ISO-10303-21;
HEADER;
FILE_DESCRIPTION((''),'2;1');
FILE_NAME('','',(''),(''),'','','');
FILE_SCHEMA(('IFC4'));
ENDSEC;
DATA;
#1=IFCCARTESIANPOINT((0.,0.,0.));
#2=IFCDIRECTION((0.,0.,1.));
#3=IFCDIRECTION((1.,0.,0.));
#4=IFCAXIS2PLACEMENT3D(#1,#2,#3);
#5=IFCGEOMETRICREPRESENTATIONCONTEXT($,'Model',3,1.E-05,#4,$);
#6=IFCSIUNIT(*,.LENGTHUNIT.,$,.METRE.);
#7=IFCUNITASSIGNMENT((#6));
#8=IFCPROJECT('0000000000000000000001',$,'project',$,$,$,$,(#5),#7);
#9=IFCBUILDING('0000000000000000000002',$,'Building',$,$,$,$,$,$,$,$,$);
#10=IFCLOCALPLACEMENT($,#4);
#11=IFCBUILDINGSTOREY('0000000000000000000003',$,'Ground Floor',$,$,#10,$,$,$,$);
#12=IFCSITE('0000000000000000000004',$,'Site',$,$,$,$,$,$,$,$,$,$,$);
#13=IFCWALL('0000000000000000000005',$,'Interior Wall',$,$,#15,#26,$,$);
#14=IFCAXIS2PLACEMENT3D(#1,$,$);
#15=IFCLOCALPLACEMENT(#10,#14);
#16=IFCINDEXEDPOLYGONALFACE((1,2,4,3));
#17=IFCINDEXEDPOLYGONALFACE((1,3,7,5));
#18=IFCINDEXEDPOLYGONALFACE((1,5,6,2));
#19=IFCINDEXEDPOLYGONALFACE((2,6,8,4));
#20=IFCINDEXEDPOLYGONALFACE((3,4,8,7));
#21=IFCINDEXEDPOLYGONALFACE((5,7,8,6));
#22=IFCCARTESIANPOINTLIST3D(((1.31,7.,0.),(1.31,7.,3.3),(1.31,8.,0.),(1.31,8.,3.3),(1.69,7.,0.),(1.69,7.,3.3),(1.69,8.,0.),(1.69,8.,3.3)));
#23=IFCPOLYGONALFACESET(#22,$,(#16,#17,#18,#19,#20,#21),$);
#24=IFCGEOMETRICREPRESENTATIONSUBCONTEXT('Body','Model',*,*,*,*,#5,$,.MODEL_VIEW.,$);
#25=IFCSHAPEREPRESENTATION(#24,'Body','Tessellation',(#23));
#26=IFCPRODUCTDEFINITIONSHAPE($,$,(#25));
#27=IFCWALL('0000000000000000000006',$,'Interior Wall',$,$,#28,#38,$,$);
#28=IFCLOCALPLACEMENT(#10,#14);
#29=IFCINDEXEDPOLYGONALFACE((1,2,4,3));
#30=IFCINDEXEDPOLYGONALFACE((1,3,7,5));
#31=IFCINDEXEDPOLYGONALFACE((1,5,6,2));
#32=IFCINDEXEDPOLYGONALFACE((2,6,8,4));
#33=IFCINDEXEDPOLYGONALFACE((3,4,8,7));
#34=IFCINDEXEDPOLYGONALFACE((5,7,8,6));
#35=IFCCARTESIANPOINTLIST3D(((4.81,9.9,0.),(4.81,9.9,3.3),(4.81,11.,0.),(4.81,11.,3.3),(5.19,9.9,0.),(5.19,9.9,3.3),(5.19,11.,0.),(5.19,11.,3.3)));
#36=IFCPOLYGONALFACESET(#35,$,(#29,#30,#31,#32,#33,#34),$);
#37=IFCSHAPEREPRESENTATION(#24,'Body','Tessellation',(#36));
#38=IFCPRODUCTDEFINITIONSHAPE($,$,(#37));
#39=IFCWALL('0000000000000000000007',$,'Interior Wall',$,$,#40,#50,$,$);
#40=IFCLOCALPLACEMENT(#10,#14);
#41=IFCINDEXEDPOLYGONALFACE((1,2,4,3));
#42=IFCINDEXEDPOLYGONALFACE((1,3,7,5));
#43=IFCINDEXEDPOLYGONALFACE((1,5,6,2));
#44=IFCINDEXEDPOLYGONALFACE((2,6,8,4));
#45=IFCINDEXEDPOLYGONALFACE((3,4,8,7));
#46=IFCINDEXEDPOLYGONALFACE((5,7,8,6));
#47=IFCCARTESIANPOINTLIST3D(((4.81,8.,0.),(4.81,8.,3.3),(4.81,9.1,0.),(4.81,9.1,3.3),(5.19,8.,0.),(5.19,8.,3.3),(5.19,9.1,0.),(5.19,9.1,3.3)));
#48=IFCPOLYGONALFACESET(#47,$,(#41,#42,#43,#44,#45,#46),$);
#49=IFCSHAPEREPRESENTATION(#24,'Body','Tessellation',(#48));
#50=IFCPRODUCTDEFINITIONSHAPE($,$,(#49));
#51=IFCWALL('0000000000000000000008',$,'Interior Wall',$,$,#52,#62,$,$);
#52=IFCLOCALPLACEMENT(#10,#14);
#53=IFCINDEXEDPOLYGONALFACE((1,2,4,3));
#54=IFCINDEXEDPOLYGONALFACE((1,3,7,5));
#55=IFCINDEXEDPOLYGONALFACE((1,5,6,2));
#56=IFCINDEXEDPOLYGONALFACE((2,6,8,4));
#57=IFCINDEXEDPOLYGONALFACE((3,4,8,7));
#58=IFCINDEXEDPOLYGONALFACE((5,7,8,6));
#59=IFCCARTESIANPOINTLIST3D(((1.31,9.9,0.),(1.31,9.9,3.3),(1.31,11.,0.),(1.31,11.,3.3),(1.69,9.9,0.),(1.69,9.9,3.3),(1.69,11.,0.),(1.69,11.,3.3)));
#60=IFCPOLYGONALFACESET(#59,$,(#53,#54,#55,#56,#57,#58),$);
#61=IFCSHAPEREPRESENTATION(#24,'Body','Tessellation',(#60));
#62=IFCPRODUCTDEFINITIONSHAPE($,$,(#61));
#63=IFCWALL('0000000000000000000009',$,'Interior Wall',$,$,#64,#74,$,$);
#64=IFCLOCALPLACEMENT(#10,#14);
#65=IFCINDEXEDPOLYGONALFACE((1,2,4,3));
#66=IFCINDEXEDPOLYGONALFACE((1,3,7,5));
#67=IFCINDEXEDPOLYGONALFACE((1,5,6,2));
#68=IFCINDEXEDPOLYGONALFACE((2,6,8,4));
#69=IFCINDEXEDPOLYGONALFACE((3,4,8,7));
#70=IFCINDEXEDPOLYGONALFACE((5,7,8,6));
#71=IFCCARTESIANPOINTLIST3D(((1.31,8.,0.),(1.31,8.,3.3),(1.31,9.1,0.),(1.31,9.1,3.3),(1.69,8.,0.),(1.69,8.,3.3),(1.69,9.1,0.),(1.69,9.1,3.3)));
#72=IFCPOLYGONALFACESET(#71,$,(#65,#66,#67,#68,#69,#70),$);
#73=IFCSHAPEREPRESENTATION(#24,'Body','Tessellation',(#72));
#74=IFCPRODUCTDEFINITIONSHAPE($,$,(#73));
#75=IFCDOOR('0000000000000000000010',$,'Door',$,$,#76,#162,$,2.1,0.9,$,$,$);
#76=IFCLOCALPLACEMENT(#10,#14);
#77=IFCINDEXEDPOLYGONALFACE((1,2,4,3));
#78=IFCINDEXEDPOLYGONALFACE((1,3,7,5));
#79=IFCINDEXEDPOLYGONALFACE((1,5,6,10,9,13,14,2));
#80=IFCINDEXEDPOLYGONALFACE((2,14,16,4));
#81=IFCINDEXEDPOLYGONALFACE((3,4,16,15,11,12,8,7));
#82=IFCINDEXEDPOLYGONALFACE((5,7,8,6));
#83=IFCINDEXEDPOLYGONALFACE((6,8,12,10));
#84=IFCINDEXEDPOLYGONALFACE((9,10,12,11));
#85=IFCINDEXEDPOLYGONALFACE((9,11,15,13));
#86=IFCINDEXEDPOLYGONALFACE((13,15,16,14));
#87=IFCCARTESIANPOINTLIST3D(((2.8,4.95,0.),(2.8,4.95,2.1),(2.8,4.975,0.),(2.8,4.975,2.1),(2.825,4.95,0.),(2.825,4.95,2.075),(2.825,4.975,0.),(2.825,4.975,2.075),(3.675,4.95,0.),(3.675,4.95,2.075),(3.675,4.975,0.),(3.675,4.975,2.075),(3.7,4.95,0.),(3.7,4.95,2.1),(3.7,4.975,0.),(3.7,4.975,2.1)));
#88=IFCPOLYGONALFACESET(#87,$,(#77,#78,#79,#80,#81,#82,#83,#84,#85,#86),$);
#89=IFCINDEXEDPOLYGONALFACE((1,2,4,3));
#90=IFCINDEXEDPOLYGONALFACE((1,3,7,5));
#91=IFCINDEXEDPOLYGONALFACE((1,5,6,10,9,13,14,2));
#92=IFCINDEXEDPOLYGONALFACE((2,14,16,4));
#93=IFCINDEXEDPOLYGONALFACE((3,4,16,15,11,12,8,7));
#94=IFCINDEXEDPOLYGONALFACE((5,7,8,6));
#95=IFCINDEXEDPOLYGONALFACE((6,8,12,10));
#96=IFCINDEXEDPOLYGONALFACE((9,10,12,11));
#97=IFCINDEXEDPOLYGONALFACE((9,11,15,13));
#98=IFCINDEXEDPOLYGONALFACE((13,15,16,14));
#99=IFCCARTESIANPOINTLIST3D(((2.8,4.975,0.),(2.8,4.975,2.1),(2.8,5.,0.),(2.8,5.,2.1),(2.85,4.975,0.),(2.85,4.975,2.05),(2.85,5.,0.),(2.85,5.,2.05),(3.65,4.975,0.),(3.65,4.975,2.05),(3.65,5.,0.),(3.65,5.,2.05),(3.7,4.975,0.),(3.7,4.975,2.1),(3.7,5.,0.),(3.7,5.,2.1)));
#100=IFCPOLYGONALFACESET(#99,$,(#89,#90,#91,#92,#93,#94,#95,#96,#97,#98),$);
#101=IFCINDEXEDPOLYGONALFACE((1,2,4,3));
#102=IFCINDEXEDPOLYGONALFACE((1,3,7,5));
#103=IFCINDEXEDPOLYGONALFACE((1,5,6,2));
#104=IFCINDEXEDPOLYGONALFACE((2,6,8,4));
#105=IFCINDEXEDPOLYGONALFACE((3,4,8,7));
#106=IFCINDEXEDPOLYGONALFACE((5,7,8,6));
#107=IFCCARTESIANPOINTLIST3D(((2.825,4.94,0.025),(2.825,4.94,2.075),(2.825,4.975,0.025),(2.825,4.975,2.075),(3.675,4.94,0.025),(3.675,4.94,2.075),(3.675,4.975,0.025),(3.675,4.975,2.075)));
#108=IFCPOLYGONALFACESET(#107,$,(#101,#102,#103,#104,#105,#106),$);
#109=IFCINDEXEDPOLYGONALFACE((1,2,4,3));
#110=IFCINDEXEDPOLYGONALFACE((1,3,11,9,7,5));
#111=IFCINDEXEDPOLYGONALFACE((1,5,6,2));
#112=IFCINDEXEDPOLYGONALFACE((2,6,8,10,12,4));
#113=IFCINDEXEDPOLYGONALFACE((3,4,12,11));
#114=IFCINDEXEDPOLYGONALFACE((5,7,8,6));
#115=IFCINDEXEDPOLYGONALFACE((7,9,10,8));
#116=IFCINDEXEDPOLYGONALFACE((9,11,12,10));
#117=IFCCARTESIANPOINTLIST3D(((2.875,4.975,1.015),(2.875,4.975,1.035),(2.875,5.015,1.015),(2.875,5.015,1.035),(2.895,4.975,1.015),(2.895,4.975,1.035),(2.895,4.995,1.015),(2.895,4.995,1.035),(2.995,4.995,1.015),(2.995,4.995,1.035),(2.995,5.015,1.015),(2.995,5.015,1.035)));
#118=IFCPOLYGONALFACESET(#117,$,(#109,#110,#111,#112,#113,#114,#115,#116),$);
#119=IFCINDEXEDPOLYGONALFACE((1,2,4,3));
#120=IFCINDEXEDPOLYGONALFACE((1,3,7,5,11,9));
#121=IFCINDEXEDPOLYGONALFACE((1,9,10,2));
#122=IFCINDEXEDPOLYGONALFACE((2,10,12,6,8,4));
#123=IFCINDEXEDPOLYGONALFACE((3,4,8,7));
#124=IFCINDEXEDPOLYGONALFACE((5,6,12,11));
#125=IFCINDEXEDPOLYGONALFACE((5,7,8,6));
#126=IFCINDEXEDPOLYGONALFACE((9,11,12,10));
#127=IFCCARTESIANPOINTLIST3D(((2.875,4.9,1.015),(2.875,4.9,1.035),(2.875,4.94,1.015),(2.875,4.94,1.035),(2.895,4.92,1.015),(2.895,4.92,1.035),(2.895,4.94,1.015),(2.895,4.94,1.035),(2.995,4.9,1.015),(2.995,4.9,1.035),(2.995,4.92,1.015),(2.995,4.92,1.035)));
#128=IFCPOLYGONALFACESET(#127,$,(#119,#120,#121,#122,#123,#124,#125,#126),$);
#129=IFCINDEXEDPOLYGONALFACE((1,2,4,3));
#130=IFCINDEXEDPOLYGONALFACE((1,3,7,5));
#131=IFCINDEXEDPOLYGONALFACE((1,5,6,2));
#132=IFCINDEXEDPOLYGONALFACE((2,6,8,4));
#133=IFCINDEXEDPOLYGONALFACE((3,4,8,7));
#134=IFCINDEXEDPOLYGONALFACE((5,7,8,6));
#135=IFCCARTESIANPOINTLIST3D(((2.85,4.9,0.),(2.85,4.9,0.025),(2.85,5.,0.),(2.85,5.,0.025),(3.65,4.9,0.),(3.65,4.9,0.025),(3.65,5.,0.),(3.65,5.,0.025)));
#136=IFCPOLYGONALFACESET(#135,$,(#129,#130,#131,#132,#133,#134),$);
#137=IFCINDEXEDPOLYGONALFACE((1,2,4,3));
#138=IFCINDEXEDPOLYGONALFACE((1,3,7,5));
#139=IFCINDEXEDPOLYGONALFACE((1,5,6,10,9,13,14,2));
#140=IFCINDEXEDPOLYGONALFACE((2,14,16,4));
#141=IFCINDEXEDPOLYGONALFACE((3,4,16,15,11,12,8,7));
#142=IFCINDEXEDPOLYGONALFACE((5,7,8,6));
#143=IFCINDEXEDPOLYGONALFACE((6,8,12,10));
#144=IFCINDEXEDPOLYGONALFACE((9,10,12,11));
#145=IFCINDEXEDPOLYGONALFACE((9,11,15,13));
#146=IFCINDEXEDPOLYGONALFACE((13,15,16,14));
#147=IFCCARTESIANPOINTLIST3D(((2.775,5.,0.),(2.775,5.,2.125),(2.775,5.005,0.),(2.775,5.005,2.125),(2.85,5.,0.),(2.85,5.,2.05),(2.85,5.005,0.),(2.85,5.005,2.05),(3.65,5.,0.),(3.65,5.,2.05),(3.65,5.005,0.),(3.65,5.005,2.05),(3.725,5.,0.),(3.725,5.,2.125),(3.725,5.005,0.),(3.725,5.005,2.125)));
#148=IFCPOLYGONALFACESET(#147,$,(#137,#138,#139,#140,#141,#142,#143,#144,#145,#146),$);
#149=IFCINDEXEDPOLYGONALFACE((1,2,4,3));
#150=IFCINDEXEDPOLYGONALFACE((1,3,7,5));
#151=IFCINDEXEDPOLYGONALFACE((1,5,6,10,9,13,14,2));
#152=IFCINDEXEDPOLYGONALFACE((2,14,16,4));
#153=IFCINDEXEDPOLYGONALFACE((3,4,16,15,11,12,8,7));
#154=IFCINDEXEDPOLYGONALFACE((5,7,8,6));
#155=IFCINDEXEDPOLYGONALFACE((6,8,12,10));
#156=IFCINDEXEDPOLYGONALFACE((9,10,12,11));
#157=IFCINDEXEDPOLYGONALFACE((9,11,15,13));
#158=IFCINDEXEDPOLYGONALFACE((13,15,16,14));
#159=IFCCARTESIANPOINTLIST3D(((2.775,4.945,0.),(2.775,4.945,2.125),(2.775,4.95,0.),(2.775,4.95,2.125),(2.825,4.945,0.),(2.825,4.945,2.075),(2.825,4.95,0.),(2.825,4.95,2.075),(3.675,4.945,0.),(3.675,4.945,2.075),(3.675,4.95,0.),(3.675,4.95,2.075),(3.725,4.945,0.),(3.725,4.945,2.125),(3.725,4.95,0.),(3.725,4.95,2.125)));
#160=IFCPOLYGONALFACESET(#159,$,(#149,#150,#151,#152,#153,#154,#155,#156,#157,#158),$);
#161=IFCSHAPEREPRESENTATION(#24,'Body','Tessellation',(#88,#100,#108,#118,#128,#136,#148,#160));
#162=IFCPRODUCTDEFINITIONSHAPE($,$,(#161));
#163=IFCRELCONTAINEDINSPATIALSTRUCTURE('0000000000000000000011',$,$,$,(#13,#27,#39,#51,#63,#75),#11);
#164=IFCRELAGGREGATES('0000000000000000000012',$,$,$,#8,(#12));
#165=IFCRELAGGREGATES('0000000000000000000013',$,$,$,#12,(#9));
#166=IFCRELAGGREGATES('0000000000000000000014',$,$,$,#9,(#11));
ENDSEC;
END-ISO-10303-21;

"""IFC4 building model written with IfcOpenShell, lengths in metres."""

from ifc_helpers import new_model, si_unit, frame, origin_with_axes, place, context, subcontext, project, spatial, line, indexed_curve, outline, extrude, element, save


model = new_model("IFC4")

# Units and contexts
model_context = context("Model", 3, precision=1e-05, world=origin_with_axes())
body_context = subcontext(model_context, "Body", "Model", "MODEL_VIEW")
ifc_project = project(units=[si_unit("LENGTHUNIT", "METRE")], contexts=[model_context])

# Site, building, storey
site = spatial("IfcSite", under=ifc_project, Name="Site")
building = spatial("IfcBuilding", under=site, Name="Building")
storey_placement = place(None, origin_with_axes())
storey = spatial("IfcBuildingStorey", under=building, at=storey_placement, Name="Ground Floor")

# Walls
wall_1_placement = place(storey_placement, frame((1.5, 8.0, 0.0), z_axis=(0.0, 0.0, 1.0), x_axis=(0.0, -1.0, 0.0)))
element("IfcWall", 1, at=wall_1_placement, inside=storey, Name="Interior Wall", context=body_context, shape_type="SweptSolid", body=[
    extrude(outline(indexed_curve([(0.0, 0.0), (0.0, 0.38), (1.0, 0.38), (1.0, 0.0), (0.0, 0.0)], self_intersect=False)), frame((0.0, -0.19, 0.0), z_axis=(0.0, 0.0, 1.0), x_axis=(1.0, 0.0, 0.0)), (0.0, 0.0, 1.0), 3.3),
])
for number, where, z_axis, x_axis, name in (
    (2, (5.0, 11.0, 0.0), (0.0, 0.0, 1.0), (0.0, -1.0, 0.0), "Interior Wall"),
    (3, (5.0, 9.1, 0.0), (0.0, 0.0, 1.0), (0.0, -1.0, 0.0), "Interior Wall"),
    (4, (1.5, 11.0, 0.0), (0.0, 0.0, 1.0), (0.0, -1.0, 0.0), "Interior Wall"),
    (5, (1.5, 9.1, 0.0), (0.0, 0.0, 1.0), (0.0, -1.0, 0.0), "Interior Wall"),
):
    element("IfcWall", number, at=place(storey_placement, frame(where, z_axis=z_axis, x_axis=x_axis)), inside=storey, Name=name, context=body_context, shape_type="SweptSolid", body=[
        extrude(outline(indexed_curve([(0.0, 0.0), (0.0, 0.38), (1.1, 0.38), (1.1, 0.0), (0.0, 0.0)], self_intersect=False)), frame((0.0, -0.19, 0.0), z_axis=(0.0, 0.0, 1.0), x_axis=(1.0, 0.0, 0.0)), (0.0, 0.0, 1.0), 3.3),
    ])

# Door
door_1_placement = place(storey_placement, frame((3.7, 5.0, 0.0), z_axis=(0.0, 0.0, 1.0), x_axis=(-1.0, 0.0, 0.0)))
element("IfcDoor", 6, at=door_1_placement, inside=storey, Name="Door", OverallHeight=2.1, OverallWidth=0.9, context=body_context, shape_type="SweptSolid", body=[
    extrude(outline(indexed_curve([(0.0, 0.0), (0.0, 2.1), (0.9, 2.1), (0.9, 0.0), (0.875, 0.0), (0.875, 2.075), (0.025, 2.075), (0.025, 0.0)], segments=[line(1, 2, 3, 4, 5, 6, 7, 8, 1)])), frame((0.0, 0.025, 0.0), z_axis=(0.0, -1.0, 0.0), x_axis=(1.0, 0.0, 0.0)), (0.0, 0.0, -1.0), 0.025),
    extrude(outline(indexed_curve([(0.0, 0.0), (0.0, 2.1), (0.9, 2.1), (0.9, 0.0), (0.85, 0.0), (0.85, 2.05), (0.05, 2.05), (0.05, 0.0)], segments=[line(1, 2, 3, 4, 5, 6, 7, 8, 1)])), frame((0.0, 0.0, 0.0), z_axis=(0.0, -1.0, 0.0), x_axis=(1.0, 0.0, 0.0)), (0.0, 0.0, -1.0), 0.025),
    extrude(outline(indexed_curve([(0.0, 0.0), (0.85, 0.0), (0.85, 0.035), (0.0, 0.035)], segments=[line(1, 2, 3, 4, 1)])), frame((0.025, 0.025, 0.025), z_axis=(0.0, 0.0, 1.0), x_axis=(1.0, 0.0, 0.0)), (0.0, 0.0, 1.0), 2.05),
    extrude(outline(indexed_curve([(0.0, 0.0), (0.0, -0.04), (-0.12, -0.04), (-0.12, -0.02), (-0.02, -0.02), (-0.02, 0.0)], segments=[line(1, 2, 3, 4, 5, 6, 1)])), frame((0.825, 0.025, 1.015), z_axis=(0.0, 0.0, 1.0), x_axis=(1.0, 0.0, 0.0)), (0.0, 0.0, 1.0), 0.02),
    extrude(outline(indexed_curve([(0.0, 0.0), (0.0, 0.04), (-0.12, 0.04), (-0.12, 0.02), (-0.02, 0.02), (-0.02, 0.0)], segments=[line(1, 2, 3, 4, 5, 6, 1)])), frame((0.825, 0.06, 1.015), z_axis=(0.0, 0.0, 1.0), x_axis=(1.0, 0.0, 0.0)), (0.0, 0.0, 1.0), 0.02),
    extrude(outline(indexed_curve([(0.0, 0.0), (0.8, 0.0), (0.8, 0.1), (0.0, 0.1)], segments=[line(1, 2, 3, 4, 1)])), frame((0.05, 0.0, 0.0), z_axis=(0.0, 0.0, 1.0), x_axis=(1.0, 0.0, 0.0)), (0.0, 0.0, 1.0), 0.025),
    extrude(outline(indexed_curve([(0.0, 0.0), (0.0, 2.125), (0.95, 2.125), (0.95, 0.0), (0.875, 0.0), (0.875, 2.05), (0.075, 2.05), (0.075, 0.0)], segments=[line(1, 2, 3, 4, 5, 6, 7, 8, 1)])), frame((-0.025, -0.005, 0.0), z_axis=(0.0, -1.0, 0.0), x_axis=(1.0, 0.0, 0.0)), (0.0, 0.0, -1.0), 0.005),
    extrude(outline(indexed_curve([(0.0, 0.0), (0.0, 2.125), (0.95, 2.125), (0.95, 0.0), (0.9, 0.0), (0.9, 2.075), (0.05, 2.075), (0.05, 0.0)], segments=[line(1, 2, 3, 4, 5, 6, 7, 8, 1)])), frame((-0.025, 0.05, 0.0), z_axis=(0.0, -1.0, 0.0), x_axis=(1.0, 0.0, 0.0)), (0.0, 0.0, -1.0), 0.005),
])

save(model, "model.ifc")
